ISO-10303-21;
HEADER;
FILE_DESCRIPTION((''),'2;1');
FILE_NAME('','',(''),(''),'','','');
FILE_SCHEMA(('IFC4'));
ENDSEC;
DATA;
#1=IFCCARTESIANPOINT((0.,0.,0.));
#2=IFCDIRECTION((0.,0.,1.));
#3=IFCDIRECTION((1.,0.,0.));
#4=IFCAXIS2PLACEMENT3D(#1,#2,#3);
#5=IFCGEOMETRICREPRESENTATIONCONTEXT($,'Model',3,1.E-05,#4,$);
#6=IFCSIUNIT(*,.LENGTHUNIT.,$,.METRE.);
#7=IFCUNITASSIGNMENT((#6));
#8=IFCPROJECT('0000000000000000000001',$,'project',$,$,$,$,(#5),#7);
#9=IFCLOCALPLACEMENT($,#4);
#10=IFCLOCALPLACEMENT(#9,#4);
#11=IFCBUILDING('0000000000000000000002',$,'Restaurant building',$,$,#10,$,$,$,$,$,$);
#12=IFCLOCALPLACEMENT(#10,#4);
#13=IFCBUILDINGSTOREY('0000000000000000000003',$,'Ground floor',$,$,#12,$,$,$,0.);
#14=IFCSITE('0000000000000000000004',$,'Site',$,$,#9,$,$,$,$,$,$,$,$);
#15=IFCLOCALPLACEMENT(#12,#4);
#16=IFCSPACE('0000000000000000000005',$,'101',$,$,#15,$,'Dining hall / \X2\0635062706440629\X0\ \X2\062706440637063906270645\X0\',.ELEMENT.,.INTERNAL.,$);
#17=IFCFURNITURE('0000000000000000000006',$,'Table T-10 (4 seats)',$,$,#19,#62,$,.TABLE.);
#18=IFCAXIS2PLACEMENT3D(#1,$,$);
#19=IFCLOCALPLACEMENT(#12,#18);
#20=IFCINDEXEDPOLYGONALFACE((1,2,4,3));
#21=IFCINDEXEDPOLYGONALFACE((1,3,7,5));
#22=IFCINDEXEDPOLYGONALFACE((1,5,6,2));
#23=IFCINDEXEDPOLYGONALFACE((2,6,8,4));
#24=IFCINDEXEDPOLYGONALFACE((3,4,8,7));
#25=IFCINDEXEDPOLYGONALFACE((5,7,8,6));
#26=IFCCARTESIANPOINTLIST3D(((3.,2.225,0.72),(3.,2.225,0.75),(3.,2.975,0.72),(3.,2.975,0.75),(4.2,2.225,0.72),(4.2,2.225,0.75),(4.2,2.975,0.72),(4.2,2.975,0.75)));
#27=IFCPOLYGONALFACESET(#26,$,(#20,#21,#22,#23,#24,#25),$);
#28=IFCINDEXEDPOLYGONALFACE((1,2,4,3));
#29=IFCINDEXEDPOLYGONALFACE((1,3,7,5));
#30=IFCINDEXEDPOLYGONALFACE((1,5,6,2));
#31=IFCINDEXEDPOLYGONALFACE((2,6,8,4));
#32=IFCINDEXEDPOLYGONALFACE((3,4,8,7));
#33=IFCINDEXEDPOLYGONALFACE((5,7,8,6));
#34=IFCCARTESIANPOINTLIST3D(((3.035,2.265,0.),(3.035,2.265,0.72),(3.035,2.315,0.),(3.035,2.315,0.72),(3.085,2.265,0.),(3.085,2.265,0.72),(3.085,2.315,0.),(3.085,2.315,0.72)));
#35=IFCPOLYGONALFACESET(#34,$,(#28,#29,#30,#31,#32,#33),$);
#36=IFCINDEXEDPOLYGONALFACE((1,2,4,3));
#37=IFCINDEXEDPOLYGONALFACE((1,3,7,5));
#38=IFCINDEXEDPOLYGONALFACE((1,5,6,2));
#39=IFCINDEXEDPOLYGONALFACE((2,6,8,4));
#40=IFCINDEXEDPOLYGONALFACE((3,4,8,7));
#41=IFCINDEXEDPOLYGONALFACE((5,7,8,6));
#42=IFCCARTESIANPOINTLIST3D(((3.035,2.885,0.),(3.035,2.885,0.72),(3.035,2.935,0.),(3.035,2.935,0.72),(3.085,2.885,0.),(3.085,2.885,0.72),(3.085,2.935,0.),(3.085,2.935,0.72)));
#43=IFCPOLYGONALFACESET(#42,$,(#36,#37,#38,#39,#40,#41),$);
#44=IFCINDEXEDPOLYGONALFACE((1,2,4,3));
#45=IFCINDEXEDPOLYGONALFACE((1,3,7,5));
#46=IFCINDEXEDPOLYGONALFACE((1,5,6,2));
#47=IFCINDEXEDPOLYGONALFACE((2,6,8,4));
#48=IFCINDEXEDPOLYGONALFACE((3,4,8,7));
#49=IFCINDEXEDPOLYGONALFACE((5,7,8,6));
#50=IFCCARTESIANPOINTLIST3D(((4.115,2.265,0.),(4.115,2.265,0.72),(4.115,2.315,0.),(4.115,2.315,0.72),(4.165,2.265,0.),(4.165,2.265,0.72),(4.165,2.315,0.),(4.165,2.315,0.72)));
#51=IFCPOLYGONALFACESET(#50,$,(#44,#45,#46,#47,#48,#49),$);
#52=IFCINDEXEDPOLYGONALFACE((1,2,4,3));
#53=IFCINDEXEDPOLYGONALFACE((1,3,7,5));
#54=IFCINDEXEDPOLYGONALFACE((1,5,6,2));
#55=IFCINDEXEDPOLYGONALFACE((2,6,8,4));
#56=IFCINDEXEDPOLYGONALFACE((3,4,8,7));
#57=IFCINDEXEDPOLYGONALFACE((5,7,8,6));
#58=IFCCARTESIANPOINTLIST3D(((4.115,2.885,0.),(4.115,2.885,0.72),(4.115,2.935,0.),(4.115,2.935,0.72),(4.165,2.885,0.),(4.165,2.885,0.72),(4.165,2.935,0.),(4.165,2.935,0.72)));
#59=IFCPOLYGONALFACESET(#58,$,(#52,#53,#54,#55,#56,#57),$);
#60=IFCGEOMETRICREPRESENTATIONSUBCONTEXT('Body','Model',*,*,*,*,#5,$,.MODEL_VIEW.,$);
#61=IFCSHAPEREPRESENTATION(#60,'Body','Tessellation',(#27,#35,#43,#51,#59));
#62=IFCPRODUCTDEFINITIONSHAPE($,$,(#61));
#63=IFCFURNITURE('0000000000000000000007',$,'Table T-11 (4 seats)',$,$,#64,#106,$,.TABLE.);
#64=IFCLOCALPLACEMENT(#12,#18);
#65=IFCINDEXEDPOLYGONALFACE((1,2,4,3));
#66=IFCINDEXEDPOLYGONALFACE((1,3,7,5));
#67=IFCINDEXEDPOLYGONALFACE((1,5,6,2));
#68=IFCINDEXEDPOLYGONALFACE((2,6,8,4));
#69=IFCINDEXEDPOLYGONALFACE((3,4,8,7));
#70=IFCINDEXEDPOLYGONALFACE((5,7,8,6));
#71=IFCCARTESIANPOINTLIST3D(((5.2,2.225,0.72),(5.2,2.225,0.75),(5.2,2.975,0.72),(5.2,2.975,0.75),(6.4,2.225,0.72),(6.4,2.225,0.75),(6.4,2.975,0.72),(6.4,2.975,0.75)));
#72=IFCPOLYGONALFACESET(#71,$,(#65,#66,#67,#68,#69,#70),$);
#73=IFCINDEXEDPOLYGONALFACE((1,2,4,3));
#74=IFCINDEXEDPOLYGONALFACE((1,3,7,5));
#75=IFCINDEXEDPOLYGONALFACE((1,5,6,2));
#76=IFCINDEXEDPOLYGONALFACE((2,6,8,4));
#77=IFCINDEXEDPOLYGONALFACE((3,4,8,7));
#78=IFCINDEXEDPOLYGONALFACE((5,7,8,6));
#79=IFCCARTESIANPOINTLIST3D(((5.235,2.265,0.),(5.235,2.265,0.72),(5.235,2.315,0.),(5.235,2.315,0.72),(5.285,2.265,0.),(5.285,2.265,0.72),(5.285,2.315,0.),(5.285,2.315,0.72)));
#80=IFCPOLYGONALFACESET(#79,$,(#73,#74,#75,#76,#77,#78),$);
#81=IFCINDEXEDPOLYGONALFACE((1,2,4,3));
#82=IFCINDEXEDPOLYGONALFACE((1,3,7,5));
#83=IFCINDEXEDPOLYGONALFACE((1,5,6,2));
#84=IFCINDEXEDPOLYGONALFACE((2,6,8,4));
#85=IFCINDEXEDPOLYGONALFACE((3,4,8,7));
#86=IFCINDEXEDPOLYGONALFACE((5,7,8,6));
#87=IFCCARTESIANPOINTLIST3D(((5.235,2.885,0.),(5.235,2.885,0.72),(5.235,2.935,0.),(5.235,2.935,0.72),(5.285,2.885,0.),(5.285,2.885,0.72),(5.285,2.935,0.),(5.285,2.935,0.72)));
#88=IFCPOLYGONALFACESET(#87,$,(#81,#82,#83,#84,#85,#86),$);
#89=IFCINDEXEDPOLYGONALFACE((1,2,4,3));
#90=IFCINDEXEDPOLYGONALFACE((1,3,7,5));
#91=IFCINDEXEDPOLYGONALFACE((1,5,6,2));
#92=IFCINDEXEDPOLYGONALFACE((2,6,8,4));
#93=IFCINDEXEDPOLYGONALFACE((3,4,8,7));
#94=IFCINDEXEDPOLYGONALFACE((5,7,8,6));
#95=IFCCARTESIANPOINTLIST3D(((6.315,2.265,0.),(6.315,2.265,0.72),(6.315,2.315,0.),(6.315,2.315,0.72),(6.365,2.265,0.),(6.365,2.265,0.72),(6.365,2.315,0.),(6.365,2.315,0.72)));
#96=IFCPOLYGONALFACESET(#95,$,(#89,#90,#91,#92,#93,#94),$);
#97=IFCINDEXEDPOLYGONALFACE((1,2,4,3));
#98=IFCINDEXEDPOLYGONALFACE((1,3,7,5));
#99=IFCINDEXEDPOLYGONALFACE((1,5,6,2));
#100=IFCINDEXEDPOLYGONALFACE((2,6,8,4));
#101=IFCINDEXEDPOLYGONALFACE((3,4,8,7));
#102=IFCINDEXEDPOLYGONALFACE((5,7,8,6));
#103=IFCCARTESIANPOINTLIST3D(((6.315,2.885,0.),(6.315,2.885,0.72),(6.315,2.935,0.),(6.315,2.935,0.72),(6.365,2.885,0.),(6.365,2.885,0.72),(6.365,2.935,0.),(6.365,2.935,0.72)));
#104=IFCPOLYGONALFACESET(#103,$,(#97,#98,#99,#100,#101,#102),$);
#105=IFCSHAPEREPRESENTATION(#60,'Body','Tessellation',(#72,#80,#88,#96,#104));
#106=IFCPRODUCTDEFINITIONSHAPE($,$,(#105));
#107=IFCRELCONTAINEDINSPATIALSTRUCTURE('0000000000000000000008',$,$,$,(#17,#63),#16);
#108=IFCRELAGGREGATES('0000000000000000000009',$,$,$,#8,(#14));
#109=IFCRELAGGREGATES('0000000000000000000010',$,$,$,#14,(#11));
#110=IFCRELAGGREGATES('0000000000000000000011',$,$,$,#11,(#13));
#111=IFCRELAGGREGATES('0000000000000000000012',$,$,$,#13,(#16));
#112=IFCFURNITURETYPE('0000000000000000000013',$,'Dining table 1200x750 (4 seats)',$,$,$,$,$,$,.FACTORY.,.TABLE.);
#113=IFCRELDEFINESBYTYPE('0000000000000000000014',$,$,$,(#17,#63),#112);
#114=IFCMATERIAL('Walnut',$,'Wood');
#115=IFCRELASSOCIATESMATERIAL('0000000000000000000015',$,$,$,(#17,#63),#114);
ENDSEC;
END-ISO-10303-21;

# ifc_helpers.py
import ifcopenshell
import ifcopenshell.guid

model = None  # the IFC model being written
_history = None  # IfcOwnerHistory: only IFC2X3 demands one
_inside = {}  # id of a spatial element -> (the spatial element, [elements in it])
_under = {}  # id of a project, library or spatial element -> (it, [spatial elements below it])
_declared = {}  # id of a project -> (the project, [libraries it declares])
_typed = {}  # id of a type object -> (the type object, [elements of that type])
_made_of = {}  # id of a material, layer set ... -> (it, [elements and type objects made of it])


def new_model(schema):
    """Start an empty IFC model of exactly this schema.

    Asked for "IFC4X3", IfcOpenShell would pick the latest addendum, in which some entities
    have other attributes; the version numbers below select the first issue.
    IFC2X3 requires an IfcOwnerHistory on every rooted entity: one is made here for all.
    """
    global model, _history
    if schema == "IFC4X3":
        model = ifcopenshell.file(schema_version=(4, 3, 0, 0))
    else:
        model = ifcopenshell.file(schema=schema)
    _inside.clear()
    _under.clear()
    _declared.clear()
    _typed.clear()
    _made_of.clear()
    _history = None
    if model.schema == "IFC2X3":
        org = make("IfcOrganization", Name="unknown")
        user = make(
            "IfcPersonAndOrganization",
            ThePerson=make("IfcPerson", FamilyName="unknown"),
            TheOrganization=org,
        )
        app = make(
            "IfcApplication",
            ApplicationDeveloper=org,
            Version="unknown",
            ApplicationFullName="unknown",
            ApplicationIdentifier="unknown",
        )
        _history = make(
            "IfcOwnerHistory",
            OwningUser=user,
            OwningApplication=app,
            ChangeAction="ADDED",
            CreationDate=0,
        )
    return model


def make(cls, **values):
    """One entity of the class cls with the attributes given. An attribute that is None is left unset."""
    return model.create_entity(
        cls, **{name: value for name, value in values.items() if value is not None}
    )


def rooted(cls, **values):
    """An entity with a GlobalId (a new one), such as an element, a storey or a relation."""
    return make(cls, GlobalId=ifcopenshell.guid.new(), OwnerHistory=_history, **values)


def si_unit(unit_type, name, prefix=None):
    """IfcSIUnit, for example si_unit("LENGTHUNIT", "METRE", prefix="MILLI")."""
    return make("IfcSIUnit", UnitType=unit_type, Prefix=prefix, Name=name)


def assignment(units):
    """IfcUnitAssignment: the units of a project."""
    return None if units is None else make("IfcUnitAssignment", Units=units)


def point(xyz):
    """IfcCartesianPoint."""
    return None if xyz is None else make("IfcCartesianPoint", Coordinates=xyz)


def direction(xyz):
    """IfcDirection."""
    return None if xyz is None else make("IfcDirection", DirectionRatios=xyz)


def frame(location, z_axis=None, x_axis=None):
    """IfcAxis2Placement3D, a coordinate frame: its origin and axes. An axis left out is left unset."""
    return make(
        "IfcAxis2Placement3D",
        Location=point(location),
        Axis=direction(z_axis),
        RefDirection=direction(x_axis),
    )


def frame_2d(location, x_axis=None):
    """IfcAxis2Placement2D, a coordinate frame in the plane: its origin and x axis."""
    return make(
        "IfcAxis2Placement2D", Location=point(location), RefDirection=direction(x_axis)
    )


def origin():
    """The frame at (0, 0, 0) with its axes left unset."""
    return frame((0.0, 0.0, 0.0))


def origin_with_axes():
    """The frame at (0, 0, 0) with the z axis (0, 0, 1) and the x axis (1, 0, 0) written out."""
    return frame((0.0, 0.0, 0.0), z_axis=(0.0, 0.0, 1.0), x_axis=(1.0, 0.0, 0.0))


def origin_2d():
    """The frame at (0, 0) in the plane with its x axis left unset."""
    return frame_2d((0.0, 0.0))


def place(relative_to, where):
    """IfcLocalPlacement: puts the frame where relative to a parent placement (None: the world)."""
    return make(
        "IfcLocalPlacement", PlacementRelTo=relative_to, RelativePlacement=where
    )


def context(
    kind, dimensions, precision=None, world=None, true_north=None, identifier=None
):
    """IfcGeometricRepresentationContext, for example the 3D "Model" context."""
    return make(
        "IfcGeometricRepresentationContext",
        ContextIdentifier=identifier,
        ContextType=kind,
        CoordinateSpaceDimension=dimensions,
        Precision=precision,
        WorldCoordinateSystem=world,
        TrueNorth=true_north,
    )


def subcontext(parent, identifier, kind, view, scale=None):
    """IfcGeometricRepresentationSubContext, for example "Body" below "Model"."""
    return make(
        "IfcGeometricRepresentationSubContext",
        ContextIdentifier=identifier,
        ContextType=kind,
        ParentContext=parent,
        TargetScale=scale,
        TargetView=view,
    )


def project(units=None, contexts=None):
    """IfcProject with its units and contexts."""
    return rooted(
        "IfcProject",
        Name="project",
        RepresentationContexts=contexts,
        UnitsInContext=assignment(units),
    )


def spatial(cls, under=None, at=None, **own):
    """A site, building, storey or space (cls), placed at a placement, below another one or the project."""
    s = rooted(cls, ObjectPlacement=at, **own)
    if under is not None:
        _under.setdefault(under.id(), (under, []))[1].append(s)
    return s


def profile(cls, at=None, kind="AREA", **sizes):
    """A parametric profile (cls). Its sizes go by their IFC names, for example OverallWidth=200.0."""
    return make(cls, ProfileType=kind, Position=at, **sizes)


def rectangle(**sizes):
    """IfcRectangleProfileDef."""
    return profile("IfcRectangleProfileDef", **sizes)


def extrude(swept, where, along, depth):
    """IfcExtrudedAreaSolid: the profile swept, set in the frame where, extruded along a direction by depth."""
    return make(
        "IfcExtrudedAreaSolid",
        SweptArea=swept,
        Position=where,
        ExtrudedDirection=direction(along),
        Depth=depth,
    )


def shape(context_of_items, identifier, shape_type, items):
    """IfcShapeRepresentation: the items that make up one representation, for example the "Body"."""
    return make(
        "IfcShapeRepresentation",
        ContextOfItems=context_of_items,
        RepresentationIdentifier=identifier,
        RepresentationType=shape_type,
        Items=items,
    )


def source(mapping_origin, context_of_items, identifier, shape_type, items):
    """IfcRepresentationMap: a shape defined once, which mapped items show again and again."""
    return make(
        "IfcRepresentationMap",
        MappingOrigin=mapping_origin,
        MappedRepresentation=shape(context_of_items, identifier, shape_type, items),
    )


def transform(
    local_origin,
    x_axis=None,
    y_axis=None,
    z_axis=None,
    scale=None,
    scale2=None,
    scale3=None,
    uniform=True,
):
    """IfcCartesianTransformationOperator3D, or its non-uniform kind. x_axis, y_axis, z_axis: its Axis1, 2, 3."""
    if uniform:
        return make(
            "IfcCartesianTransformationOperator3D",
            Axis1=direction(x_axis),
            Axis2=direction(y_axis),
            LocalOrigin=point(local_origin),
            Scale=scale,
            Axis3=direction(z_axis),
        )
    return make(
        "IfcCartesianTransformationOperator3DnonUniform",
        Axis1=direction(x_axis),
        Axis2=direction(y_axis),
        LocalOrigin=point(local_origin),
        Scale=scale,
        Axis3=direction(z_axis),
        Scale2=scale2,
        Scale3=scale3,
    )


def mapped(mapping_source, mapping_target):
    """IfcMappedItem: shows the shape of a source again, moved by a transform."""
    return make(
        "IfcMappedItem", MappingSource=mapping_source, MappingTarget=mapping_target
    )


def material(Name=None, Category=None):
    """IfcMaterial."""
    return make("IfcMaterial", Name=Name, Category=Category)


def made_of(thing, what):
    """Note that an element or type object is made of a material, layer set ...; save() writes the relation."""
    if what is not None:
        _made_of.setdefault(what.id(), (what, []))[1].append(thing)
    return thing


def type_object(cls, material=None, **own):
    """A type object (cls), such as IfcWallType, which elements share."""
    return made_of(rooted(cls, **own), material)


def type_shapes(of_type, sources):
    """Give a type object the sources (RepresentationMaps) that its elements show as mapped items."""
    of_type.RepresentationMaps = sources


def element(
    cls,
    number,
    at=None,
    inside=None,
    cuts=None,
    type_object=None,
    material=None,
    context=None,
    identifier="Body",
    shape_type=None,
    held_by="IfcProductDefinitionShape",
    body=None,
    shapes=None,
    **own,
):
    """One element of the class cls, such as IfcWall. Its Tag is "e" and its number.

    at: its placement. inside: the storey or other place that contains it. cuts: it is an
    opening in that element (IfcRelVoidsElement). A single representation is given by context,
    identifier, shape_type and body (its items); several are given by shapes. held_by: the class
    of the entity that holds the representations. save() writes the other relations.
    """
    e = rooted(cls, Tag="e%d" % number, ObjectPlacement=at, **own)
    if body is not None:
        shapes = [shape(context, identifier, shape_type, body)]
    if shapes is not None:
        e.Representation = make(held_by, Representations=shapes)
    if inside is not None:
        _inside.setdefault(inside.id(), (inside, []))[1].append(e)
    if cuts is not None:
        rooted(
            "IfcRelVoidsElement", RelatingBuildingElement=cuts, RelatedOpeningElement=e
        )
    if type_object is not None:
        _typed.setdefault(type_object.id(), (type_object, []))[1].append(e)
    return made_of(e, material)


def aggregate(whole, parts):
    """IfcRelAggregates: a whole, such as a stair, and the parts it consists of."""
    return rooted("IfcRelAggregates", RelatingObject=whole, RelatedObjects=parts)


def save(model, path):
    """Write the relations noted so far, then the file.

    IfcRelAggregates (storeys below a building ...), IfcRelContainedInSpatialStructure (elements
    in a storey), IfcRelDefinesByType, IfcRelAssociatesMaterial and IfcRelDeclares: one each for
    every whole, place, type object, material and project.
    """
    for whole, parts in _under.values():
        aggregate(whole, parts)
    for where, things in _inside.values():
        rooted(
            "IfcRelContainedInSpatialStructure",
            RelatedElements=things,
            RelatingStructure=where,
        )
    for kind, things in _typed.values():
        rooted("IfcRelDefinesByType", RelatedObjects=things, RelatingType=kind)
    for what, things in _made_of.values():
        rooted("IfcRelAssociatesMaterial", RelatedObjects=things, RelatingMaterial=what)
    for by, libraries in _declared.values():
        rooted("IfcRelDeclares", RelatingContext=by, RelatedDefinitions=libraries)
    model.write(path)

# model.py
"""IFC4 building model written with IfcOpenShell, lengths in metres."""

from ifc_helpers import new_model, si_unit, frame, origin, origin_with_axes, origin_2d, place, context, subcontext, project, spatial, rectangle, extrude, source, transform, mapped, material, type_object, type_shapes, element, save


model = new_model("IFC4")

# Units and contexts
model_context = context("Model", 3, precision=1e-05, world=origin_with_axes())
body_context = subcontext(model_context, "Body", "Model", "MODEL_VIEW")
ifc_project = project(units=[si_unit("LENGTHUNIT", "METRE")], contexts=[model_context])

# Site, building, storey, space
site_placement = place(None, origin_with_axes())
site = spatial("IfcSite", under=ifc_project, at=site_placement, Name="Site")
building_placement = place(site_placement, origin_with_axes())
building = spatial("IfcBuilding", under=site, at=building_placement, Name="Restaurant building")
storey_placement = place(building_placement, origin_with_axes())
storey = spatial("IfcBuildingStorey", under=building, at=storey_placement, Name="Ground floor", Elevation=0.0)
space_placement = place(storey_placement, origin_with_axes())
space = spatial("IfcSpace", under=storey, at=space_placement, Name="101", LongName="Dining hall / صالة الطعام", CompositionType="ELEMENT", PredefinedType="INTERNAL")

# Furniture
ifc_material_1 = material(Name="Walnut", Category="Wood")
furniture_type_1 = type_object("IfcFurnitureType", Name="Dining table 1200x750 (4 seats)", AssemblyPlace="FACTORY", PredefinedType="TABLE")
shared_shape_1 = source(origin(), body_context, "Body", "SweptSolid", [
    extrude(rectangle(XDim=1.2, YDim=0.75, at=origin_2d()), frame((0.0, 0.0, 0.72)), (0.0, 0.0, 1.0), 0.03),
    extrude(rectangle(XDim=0.05, YDim=0.05, at=origin_2d()), frame((-0.54, -0.31, 0.0)), (0.0, 0.0, 1.0), 0.72),
    extrude(rectangle(XDim=0.05, YDim=0.05, at=origin_2d()), frame((-0.54, 0.31, 0.0)), (0.0, 0.0, 1.0), 0.72),
    extrude(rectangle(XDim=0.05, YDim=0.05, at=origin_2d()), frame((0.54, -0.31, 0.0)), (0.0, 0.0, 1.0), 0.72),
    extrude(rectangle(XDim=0.05, YDim=0.05, at=origin_2d()), frame((0.54, 0.31, 0.0)), (0.0, 0.0, 1.0), 0.72),
])
type_shapes(furniture_type_1, [shared_shape_1])
for number, where, name in (
    (1, (3.6, 2.6, 0.0), "Table T-10 (4 seats)"),
    (2, (5.8, 2.6, 0.0), "Table T-11 (4 seats)"),
):
    element("IfcFurniture", number, at=place(storey_placement, frame(where)), inside=space, type_object=furniture_type_1, material=ifc_material_1, Name=name, PredefinedType="TABLE", context=body_context, shape_type="MappedRepresentation", body=[
        mapped(shared_shape_1, transform((0.0, 0.0, 0.0))),
    ])

save(model, "model.ifc")
